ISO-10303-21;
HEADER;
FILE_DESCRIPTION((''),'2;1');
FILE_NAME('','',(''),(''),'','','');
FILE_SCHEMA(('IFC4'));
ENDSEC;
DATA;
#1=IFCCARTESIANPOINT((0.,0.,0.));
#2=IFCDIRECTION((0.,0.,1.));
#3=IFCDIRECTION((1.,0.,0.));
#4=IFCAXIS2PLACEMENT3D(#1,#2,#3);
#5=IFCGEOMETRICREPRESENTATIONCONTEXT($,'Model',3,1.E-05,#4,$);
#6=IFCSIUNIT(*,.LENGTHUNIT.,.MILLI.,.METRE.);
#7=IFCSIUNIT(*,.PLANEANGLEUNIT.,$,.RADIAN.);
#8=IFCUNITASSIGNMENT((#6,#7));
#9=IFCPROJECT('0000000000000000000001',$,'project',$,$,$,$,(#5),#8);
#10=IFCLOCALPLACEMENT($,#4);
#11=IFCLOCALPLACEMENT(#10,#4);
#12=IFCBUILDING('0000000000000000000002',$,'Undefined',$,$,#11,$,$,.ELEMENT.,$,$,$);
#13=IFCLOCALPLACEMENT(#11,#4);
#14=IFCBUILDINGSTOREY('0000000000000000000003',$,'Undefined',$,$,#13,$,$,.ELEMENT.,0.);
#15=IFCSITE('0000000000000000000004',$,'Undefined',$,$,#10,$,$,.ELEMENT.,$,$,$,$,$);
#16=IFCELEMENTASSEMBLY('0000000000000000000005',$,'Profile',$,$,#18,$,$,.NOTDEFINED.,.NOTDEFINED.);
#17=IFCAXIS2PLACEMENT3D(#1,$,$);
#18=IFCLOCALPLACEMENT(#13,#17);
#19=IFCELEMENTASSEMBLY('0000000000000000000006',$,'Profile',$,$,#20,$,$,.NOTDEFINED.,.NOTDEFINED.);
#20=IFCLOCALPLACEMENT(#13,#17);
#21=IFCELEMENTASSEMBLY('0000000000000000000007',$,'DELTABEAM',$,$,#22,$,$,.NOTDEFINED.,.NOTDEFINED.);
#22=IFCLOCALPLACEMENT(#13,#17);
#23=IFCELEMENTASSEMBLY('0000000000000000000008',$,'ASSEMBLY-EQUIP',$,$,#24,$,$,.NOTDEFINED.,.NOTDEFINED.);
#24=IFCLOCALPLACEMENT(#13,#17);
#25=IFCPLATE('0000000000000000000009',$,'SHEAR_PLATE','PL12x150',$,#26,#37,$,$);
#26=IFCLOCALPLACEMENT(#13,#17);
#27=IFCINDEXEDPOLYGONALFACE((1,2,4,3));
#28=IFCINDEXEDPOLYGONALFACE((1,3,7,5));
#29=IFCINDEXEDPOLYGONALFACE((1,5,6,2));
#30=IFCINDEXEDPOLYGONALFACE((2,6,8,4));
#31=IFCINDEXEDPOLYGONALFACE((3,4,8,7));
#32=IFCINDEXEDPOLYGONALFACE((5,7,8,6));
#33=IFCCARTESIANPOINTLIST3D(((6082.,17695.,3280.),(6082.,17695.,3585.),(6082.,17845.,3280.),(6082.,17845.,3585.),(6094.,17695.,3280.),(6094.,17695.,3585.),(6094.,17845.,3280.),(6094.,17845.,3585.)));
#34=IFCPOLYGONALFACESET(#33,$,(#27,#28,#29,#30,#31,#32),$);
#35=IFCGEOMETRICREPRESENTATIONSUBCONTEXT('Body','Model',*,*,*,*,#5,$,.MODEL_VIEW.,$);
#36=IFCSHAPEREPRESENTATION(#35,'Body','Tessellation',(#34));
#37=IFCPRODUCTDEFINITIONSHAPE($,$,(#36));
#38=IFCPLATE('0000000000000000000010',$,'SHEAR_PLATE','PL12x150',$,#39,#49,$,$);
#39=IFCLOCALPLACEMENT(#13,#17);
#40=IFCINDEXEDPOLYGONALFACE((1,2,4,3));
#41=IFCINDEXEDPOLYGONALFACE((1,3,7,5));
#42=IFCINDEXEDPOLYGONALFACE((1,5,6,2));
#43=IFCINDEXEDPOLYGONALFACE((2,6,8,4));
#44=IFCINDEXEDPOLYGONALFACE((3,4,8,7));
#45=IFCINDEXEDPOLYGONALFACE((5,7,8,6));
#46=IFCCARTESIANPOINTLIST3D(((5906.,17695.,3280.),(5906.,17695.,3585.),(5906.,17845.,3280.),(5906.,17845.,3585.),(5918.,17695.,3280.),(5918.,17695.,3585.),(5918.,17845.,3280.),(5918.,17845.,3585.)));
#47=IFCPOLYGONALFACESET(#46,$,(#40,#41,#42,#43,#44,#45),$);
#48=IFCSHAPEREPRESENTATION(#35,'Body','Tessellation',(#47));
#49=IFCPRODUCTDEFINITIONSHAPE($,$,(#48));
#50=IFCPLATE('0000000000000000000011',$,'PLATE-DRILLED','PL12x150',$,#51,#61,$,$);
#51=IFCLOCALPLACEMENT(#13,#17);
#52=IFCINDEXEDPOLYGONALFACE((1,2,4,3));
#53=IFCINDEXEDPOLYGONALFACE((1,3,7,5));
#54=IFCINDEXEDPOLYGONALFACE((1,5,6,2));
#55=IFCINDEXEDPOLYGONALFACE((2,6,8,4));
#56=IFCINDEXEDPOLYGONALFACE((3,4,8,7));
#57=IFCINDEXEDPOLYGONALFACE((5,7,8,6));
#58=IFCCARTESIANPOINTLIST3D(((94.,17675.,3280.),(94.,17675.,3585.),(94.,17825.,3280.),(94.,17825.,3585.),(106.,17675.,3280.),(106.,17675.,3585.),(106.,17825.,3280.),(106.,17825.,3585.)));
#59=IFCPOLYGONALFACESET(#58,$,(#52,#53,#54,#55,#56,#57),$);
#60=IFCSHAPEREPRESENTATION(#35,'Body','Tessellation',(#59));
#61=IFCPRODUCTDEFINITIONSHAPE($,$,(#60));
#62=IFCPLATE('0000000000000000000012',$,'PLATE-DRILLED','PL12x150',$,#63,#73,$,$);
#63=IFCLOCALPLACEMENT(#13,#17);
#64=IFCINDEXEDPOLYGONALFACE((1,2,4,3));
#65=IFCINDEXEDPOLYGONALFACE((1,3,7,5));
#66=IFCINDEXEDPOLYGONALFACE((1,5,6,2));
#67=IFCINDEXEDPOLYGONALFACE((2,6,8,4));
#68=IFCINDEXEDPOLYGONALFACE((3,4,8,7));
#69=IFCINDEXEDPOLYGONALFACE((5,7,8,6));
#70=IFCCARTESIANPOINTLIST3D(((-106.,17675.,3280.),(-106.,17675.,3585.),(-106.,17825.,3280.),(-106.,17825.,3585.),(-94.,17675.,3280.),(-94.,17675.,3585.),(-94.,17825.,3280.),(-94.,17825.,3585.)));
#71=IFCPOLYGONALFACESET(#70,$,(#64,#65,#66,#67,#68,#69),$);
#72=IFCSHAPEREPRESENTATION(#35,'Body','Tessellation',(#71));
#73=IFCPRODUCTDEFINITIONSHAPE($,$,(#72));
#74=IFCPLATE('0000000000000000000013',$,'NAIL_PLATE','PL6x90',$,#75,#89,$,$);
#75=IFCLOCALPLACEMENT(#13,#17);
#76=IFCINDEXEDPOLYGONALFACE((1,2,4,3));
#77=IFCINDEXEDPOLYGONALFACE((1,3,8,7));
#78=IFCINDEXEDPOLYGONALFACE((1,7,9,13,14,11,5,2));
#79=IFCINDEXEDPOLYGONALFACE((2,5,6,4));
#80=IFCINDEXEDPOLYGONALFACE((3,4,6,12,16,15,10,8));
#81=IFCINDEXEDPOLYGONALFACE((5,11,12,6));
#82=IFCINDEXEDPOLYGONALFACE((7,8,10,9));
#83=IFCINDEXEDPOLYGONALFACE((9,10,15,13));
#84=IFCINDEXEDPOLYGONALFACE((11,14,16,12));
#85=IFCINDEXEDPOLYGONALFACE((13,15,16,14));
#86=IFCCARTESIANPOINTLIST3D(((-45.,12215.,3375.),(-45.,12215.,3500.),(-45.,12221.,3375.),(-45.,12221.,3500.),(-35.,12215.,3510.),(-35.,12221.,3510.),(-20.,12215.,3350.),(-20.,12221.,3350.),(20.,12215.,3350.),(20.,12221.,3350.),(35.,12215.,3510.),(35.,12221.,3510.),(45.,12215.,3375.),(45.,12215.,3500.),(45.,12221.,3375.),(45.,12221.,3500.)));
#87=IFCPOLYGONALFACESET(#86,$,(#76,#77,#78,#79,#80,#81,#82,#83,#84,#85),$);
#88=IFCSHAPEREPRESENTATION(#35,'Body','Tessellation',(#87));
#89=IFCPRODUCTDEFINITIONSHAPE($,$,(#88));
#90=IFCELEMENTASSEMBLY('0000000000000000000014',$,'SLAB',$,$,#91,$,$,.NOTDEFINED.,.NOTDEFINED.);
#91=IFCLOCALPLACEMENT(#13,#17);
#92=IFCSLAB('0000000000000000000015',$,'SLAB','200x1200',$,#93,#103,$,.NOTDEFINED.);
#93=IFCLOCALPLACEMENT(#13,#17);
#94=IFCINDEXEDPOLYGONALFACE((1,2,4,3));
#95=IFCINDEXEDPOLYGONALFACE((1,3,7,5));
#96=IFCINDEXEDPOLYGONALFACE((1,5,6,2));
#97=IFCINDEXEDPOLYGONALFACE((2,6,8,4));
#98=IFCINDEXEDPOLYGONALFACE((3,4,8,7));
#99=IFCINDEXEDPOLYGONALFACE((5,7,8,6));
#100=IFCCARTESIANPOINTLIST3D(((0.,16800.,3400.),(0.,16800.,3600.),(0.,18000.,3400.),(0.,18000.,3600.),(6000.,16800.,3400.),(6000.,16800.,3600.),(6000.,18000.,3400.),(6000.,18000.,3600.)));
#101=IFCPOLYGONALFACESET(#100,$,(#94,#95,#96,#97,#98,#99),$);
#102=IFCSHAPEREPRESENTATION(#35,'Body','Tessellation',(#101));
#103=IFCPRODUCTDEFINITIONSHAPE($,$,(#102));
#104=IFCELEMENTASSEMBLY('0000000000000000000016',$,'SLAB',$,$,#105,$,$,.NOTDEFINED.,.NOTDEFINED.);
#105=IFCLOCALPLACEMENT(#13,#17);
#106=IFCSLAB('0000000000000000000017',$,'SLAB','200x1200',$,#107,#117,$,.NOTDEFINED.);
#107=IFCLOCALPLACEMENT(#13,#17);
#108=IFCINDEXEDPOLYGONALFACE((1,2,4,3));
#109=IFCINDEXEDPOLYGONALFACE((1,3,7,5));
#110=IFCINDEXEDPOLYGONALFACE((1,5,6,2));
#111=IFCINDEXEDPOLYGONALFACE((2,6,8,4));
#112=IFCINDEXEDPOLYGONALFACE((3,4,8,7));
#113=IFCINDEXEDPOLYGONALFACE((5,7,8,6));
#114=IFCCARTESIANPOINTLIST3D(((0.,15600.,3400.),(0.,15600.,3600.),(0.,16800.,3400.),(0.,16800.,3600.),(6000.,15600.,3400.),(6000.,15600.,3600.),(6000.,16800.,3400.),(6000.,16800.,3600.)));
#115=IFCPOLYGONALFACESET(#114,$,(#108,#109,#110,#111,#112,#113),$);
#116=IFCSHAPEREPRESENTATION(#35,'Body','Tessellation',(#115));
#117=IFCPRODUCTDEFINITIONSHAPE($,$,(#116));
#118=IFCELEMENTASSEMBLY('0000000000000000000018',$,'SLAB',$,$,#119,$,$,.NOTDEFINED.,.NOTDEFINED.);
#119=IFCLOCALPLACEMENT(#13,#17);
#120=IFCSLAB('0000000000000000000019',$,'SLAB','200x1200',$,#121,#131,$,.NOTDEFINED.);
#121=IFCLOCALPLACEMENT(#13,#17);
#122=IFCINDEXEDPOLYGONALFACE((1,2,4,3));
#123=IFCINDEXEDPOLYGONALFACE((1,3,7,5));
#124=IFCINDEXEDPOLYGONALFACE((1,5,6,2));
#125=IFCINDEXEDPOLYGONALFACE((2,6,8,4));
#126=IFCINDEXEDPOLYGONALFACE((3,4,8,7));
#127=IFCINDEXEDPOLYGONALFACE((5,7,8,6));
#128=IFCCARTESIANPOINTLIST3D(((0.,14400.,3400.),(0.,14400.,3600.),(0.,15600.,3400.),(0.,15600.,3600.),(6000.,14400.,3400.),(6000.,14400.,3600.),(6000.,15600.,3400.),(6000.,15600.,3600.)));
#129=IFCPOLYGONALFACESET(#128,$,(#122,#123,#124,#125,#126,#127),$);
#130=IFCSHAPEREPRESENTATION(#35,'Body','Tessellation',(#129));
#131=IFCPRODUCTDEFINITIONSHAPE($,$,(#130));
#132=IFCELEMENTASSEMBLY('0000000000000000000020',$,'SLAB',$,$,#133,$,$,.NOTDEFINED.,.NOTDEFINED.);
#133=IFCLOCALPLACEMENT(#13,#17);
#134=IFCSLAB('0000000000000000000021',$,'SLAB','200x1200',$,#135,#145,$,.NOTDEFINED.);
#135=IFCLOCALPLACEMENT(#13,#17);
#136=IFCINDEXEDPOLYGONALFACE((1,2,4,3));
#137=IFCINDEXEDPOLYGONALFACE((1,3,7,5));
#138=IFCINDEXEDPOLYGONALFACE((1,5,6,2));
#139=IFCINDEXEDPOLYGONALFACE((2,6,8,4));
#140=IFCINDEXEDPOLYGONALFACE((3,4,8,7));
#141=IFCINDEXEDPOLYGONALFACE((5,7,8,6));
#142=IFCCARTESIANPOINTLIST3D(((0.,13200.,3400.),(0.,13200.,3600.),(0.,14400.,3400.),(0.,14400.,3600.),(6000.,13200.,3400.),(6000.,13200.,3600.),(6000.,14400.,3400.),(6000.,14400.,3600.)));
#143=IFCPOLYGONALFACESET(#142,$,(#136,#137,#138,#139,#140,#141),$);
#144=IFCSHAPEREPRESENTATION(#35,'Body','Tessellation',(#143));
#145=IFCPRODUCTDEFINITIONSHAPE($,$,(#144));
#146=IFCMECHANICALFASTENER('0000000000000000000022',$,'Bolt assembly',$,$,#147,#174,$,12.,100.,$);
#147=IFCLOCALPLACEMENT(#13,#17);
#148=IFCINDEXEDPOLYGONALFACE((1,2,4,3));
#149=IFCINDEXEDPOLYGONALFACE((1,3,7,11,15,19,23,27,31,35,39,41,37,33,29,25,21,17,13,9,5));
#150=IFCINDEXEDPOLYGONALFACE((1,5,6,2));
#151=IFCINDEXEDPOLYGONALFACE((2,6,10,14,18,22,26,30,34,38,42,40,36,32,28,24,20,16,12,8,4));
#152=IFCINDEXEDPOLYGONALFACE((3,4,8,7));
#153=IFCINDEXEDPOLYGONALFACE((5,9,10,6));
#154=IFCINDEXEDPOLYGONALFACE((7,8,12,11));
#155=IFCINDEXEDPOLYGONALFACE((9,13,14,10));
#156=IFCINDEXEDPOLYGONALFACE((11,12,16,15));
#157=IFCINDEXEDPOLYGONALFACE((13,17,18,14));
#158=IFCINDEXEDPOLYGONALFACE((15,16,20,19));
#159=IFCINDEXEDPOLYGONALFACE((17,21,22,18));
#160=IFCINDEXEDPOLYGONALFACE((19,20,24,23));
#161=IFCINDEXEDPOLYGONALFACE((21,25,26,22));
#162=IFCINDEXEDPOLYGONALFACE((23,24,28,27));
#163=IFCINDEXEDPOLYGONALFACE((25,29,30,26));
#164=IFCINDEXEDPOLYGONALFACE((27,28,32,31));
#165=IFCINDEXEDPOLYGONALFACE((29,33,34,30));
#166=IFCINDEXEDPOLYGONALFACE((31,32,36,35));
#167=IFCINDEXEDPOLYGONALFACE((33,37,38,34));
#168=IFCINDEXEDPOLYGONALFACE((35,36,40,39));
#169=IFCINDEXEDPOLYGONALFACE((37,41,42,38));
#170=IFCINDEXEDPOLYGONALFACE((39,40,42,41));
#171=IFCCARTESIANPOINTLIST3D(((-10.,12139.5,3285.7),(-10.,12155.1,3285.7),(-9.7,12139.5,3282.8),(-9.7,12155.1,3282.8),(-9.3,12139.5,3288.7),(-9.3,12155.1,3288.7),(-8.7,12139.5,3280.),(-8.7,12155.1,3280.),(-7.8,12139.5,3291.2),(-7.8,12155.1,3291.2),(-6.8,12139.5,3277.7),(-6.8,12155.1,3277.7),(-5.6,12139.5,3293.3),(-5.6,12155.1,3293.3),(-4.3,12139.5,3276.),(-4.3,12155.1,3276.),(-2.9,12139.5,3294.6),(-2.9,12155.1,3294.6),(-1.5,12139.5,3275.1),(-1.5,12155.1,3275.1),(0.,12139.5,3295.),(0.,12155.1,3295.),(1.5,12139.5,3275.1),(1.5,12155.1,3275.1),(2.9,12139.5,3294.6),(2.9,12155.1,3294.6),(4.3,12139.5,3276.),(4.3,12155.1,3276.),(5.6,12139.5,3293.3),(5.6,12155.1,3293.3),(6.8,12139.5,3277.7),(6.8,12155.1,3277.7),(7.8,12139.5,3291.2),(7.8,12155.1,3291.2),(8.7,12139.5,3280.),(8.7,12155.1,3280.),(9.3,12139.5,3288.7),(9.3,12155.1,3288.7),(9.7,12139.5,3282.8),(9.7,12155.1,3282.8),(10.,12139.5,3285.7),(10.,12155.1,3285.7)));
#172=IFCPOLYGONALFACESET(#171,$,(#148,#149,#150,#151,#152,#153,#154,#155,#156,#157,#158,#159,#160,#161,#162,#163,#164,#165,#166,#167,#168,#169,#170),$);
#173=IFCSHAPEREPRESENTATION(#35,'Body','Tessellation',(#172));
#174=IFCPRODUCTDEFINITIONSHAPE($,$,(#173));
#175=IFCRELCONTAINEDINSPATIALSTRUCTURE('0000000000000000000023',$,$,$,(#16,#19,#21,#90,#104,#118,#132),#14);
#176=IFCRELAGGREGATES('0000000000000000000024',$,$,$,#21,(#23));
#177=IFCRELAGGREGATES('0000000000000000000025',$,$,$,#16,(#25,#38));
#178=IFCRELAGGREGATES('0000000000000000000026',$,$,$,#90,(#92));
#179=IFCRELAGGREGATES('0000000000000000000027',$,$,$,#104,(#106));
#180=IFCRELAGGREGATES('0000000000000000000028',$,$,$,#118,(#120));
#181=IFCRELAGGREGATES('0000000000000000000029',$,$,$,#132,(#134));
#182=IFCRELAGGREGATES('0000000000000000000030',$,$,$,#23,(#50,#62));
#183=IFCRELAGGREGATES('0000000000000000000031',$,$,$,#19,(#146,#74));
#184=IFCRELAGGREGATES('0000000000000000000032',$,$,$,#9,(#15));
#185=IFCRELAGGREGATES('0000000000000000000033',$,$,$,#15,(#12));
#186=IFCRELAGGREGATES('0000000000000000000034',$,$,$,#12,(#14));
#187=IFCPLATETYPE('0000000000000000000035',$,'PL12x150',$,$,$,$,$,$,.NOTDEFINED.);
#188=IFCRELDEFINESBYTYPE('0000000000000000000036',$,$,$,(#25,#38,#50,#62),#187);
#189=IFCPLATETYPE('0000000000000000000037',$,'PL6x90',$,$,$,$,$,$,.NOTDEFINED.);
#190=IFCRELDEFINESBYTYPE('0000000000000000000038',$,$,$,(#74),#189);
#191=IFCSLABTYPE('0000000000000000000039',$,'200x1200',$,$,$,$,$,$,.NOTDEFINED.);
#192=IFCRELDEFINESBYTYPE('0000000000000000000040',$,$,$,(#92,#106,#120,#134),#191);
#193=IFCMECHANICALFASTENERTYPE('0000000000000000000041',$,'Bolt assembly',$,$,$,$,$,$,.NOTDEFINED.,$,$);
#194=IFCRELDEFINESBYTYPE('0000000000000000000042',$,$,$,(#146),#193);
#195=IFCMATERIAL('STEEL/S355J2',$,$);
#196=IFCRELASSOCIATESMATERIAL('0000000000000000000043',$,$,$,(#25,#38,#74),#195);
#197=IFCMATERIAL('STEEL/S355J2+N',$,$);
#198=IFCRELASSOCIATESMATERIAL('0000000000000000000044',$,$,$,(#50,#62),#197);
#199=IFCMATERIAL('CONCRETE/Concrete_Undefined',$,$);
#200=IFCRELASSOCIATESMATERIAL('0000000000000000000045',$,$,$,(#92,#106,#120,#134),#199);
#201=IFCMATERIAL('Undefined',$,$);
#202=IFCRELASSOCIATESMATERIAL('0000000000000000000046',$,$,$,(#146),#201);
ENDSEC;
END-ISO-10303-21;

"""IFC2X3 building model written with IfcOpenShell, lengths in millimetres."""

from ifc_helpers import new_model, si_unit, frame, origin_with_axes, origin_2d_with_axis, place, context, subcontext, project, spatial, polyline, circle, outline, extrude, source, transform, mapped, material, type_object, element, aggregate, save


model = new_model("IFC2X3")

# Units and contexts
model_context = context("Model", 3, precision=1e-05, world=origin_with_axes())
body_context = subcontext(model_context, "Body", "Model", "MODEL_VIEW")
ifc_project = project(units=[si_unit("LENGTHUNIT", "METRE", prefix="MILLI"), si_unit("PLANEANGLEUNIT", "RADIAN")], contexts=[model_context])

# Site, building, storey
site_placement = place(None, origin_with_axes())
site = spatial("IfcSite", under=ifc_project, at=site_placement, Name="Undefined", CompositionType="ELEMENT")
building_placement = place(site_placement, origin_with_axes())
building = spatial("IfcBuilding", under=site, at=building_placement, Name="Undefined", CompositionType="ELEMENT")
storey_placement = place(building_placement, origin_with_axes())
storey = spatial("IfcBuildingStorey", under=building, at=storey_placement, Name="Undefined", CompositionType="ELEMENT", Elevation=0.0)

# Shared definitions
ifc_material_1 = material(Name="CONCRETE/Concrete_Undefined")

# Element assembly
assembly_1_placement = place(storey_placement, origin_with_axes())
assembly_1 = element("IfcElementAssembly", 1, at=assembly_1_placement, inside=storey, Name="Profile", AssemblyPlace="NOTDEFINED", PredefinedType="NOTDEFINED")

# Shared definitions
ifc_material_2 = material(Name="STEEL/S355J2")

# Element assembly
assembly_2_placement = place(storey_placement, origin_with_axes())
assembly_2 = element("IfcElementAssembly", 2, at=assembly_2_placement, inside=storey, Name="Profile", AssemblyPlace="NOTDEFINED", PredefinedType="NOTDEFINED")

# Element assemblies
ifc_material_3 = material(Name="STEEL/S355J2+N")
assembly_3_placement = place(storey_placement, origin_with_axes())
assembly_3 = element("IfcElementAssembly", 3, at=assembly_3_placement, inside=storey, Name="DELTABEAM", AssemblyPlace="NOTDEFINED", PredefinedType="NOTDEFINED")
assembly_4_placement = place(assembly_3_placement, origin_with_axes())
assembly_4 = element("IfcElementAssembly", 4, at=assembly_4_placement, Name="ASSEMBLY-EQUIP", AssemblyPlace="NOTDEFINED", PredefinedType="NOTDEFINED")
aggregate(assembly_3, [assembly_4])

# Plates
plate_type_1 = type_object("IfcPlateType", Name="PL12x150", PredefinedType="NOTDEFINED")
plate_1_placement = place(assembly_1_placement, frame((6088.0, 17845.0, 3585.0), z_axis=(1.0, 0.0, 0.0), x_axis=(0.0, -1.0, 0.0)))
plate_1 = element("IfcPlate", 5, at=plate_1_placement, type_object=plate_type_1, material=ifc_material_2, Name="SHEAR_PLATE", Description="PL12x150", context=body_context, shape_type="SweptSolid", body=[
    extrude(outline(polyline([(0.0, 0.0), (150.0, 0.0), (150.0, 0.0), (150.0, 305.0), (150.0, 305.0), (0.0, 305.0), (0.0, 305.0), (0.0, 0.0)])), frame((0.0, 0.0, -6.0), z_axis=(0.0, 0.0, 1.0), x_axis=(1.0, 0.0, 0.0)), (0.0, 0.0, 1.0), 12.0),
])
plate_2_placement = place(assembly_1_placement, frame((5912.0, 17845.0, 3585.0), z_axis=(1.0, 0.0, 0.0), x_axis=(0.0, -1.0, 0.0)))
plate_2 = element("IfcPlate", 6, at=plate_2_placement, type_object=plate_type_1, material=ifc_material_2, Name="SHEAR_PLATE", Description="PL12x150", context=body_context, shape_type="SweptSolid", body=[
    extrude(outline(polyline([(0.0, 0.0), (150.0, 0.0), (150.0, 0.0), (150.0, 305.0), (150.0, 305.0), (0.0, 305.0), (0.0, 305.0), (0.0, 0.0)])), frame((0.0, 0.0, -6.0), z_axis=(0.0, 0.0, 1.0), x_axis=(1.0, 0.0, 0.0)), (0.0, 0.0, 1.0), 12.0),
])
aggregate(assembly_1, [plate_1, plate_2])
plate_3_placement = place(assembly_4_placement, frame((100.0, 17675.0, 3585.0), z_axis=(-1.0, 0.0, 0.0), x_axis=(0.0, 1.0, 0.0)))
plate_3 = element("IfcPlate", 7, at=plate_3_placement, type_object=plate_type_1, material=ifc_material_3, Name="PLATE-DRILLED", Description="PL12x150", context=body_context, shape_type="SweptSolid", body=[
    extrude(outline(polyline([(0.0, 0.0), (150.0, 0.0), (150.0, 0.0), (150.0, 305.0), (150.0, 305.0), (0.0, 305.0), (0.0, 305.0), (0.0, 0.0)])), frame((0.0, 0.0, -6.0), z_axis=(0.0, 0.0, 1.0), x_axis=(1.0, 0.0, 0.0)), (0.0, 0.0, 1.0), 12.0),
])
plate_4_placement = place(assembly_4_placement, frame((-100.0, 17675.0, 3585.0), z_axis=(-1.0, 0.0, 0.0), x_axis=(0.0, 1.0, 0.0)))
plate_4 = element("IfcPlate", 8, at=plate_4_placement, type_object=plate_type_1, material=ifc_material_3, Name="PLATE-DRILLED", Description="PL12x150", context=body_context, shape_type="SweptSolid", body=[
    extrude(outline(polyline([(0.0, 0.0), (150.0, 0.0), (150.0, 0.0), (150.0, 305.0), (150.0, 305.0), (0.0, 305.0), (0.0, 305.0), (0.0, 0.0)])), frame((0.0, 0.0, -6.0), z_axis=(0.0, 0.0, 1.0), x_axis=(1.0, 0.0, 0.0)), (0.0, 0.0, 1.0), 12.0),
])
plate_type_2 = type_object("IfcPlateType", Name="PL6x90", PredefinedType="NOTDEFINED")
plate_5_placement = place(assembly_2_placement, frame((45.0, 12218.0, 3510.0), z_axis=(0.0, -1.0, 0.0), x_axis=(-1.0, 0.0, 0.0)))
plate_5 = element("IfcPlate", 9, at=plate_5_placement, type_object=plate_type_2, material=ifc_material_2, Name="NAIL_PLATE", Description="PL6x90", context=body_context, shape_type="SweptSolid", body=[
    extrude(outline(polyline([(0.0, 10.0), (10.0, 0.0), (80.0, 0.0), (90.0, 10.0), (90.0, 135.0), (65.0, 160.0), (25.0, 160.0), (0.0, 135.0), (0.0, 10.0)])), frame((0.0, 0.0, -3.0), z_axis=(0.0, 0.0, 1.0), x_axis=(1.0, 0.0, 0.0)), (0.0, 0.0, 1.0), 6.0),
])

# Element assemblies, slabs
assembly_5_placement = place(storey_placement, origin_with_axes())
assembly_5 = element("IfcElementAssembly", 10, at=assembly_5_placement, inside=storey, Name="SLAB", AssemblyPlace="NOTDEFINED", PredefinedType="NOTDEFINED")
slab_type = type_object("IfcSlabType", Name="200x1200", PredefinedType="NOTDEFINED")
slab_1_placement = place(assembly_5_placement, frame((6000.0, 16800.0, 3500.0), z_axis=(0.0, 0.0, 1.0), x_axis=(0.0, 1.0, 0.0)))
slab_1 = element("IfcSlab", 11, at=slab_1_placement, type_object=slab_type, material=ifc_material_1, Name="SLAB", Description="200x1200", PredefinedType="NOTDEFINED", context=body_context, shape_type="SweptSolid", body=[
    extrude(outline(polyline([(0.0, 0.0), (1200.0, 0.0), (1200.0, 6000.0), (0.0, 6000.0), (0.0, 0.0)])), frame((0.0, 0.0, -100.0), z_axis=(0.0, 0.0, 1.0), x_axis=(1.0, 0.0, 0.0)), (0.0, 0.0, 1.0), 200.0),
])
aggregate(assembly_5, [slab_1])
assembly_6_placement = place(storey_placement, origin_with_axes())
assembly_6 = element("IfcElementAssembly", 12, at=assembly_6_placement, inside=storey, Name="SLAB", AssemblyPlace="NOTDEFINED", PredefinedType="NOTDEFINED")
slab_2_placement = place(assembly_6_placement, frame((6000.0, 15600.0, 3500.0), z_axis=(0.0, 0.0, 1.0), x_axis=(0.0, 1.0, 0.0)))
slab_2 = element("IfcSlab", 13, at=slab_2_placement, type_object=slab_type, material=ifc_material_1, Name="SLAB", Description="200x1200", PredefinedType="NOTDEFINED", context=body_context, shape_type="SweptSolid", body=[
    extrude(outline(polyline([(0.0, 0.0), (1200.0, 0.0), (1200.0, 6000.0), (0.0, 6000.0), (0.0, 0.0)])), frame((0.0, 0.0, -100.0), z_axis=(0.0, 0.0, 1.0), x_axis=(1.0, 0.0, 0.0)), (0.0, 0.0, 1.0), 200.0),
])
aggregate(assembly_6, [slab_2])
assembly_7_placement = place(storey_placement, origin_with_axes())
assembly_7 = element("IfcElementAssembly", 14, at=assembly_7_placement, inside=storey, Name="SLAB", AssemblyPlace="NOTDEFINED", PredefinedType="NOTDEFINED")
slab_3_placement = place(assembly_7_placement, frame((6000.0, 14400.0, 3500.0), z_axis=(0.0, 0.0, 1.0), x_axis=(0.0, 1.0, 0.0)))
slab_3 = element("IfcSlab", 15, at=slab_3_placement, type_object=slab_type, material=ifc_material_1, Name="SLAB", Description="200x1200", PredefinedType="NOTDEFINED", context=body_context, shape_type="SweptSolid", body=[
    extrude(outline(polyline([(0.0, 0.0), (1200.0, 0.0), (1200.0, 6000.0), (0.0, 6000.0), (0.0, 0.0)])), frame((0.0, 0.0, -100.0), z_axis=(0.0, 0.0, 1.0), x_axis=(1.0, 0.0, 0.0)), (0.0, 0.0, 1.0), 200.0),
])
aggregate(assembly_7, [slab_3])
assembly_8_placement = place(storey_placement, origin_with_axes())
assembly_8 = element("IfcElementAssembly", 16, at=assembly_8_placement, inside=storey, Name="SLAB", AssemblyPlace="NOTDEFINED", PredefinedType="NOTDEFINED")
slab_4_placement = place(assembly_8_placement, frame((6000.0, 13200.0, 3500.0), z_axis=(0.0, 0.0, 1.0), x_axis=(0.0, 1.0, 0.0)))
slab_4 = element("IfcSlab", 17, at=slab_4_placement, type_object=slab_type, material=ifc_material_1, Name="SLAB", Description="200x1200", PredefinedType="NOTDEFINED", context=body_context, shape_type="SweptSolid", body=[
    extrude(outline(polyline([(0.0, 0.0), (1200.0, 0.0), (1200.0, 6000.0), (0.0, 6000.0), (0.0, 0.0)])), frame((0.0, 0.0, -100.0), z_axis=(0.0, 0.0, 1.0), x_axis=(1.0, 0.0, 0.0)), (0.0, 0.0, 1.0), 200.0),
])
aggregate(assembly_8, [slab_4])

# Mechanical fastener
mechanical_fastener_type = type_object("IfcMechanicalFastenerType", Name="Bolt assembly")
aggregate(assembly_4, [plate_3, plate_4])
ifc_material_4 = material(Name="Undefined")
shared_shape_1 = source(origin_with_axes(), body_context, "Body", "SweptSolid", [
    extrude(circle(Radius=10.0, at=origin_2d_with_axis()), frame((0.0, -15.5, 0.0), z_axis=(0.0, 1.0, 0.0), x_axis=(1.0, 0.0, 0.0)), (0.0, 0.0, 1.0), 15.6),
])
mechanical_fastener_1_placement = place(assembly_2_placement, frame((0.0, 12155.0, 3285.0), z_axis=(-1.0, 0.0, 0.0), x_axis=(0.0, 0.0, 1.0)))
mechanical_fastener_1 = element("IfcMechanicalFastener", 18, at=mechanical_fastener_1_placement, type_object=mechanical_fastener_type, material=ifc_material_4, Name="Bolt assembly", NominalDiameter=12.0, NominalLength=100.0, context=body_context, shape_type="MappedRepresentation", body=[
    mapped(shared_shape_1, transform((0.0, 0.0, 0.0))),
])
aggregate(assembly_2, [mechanical_fastener_1, plate_5])

save(model, "model.ifc")
